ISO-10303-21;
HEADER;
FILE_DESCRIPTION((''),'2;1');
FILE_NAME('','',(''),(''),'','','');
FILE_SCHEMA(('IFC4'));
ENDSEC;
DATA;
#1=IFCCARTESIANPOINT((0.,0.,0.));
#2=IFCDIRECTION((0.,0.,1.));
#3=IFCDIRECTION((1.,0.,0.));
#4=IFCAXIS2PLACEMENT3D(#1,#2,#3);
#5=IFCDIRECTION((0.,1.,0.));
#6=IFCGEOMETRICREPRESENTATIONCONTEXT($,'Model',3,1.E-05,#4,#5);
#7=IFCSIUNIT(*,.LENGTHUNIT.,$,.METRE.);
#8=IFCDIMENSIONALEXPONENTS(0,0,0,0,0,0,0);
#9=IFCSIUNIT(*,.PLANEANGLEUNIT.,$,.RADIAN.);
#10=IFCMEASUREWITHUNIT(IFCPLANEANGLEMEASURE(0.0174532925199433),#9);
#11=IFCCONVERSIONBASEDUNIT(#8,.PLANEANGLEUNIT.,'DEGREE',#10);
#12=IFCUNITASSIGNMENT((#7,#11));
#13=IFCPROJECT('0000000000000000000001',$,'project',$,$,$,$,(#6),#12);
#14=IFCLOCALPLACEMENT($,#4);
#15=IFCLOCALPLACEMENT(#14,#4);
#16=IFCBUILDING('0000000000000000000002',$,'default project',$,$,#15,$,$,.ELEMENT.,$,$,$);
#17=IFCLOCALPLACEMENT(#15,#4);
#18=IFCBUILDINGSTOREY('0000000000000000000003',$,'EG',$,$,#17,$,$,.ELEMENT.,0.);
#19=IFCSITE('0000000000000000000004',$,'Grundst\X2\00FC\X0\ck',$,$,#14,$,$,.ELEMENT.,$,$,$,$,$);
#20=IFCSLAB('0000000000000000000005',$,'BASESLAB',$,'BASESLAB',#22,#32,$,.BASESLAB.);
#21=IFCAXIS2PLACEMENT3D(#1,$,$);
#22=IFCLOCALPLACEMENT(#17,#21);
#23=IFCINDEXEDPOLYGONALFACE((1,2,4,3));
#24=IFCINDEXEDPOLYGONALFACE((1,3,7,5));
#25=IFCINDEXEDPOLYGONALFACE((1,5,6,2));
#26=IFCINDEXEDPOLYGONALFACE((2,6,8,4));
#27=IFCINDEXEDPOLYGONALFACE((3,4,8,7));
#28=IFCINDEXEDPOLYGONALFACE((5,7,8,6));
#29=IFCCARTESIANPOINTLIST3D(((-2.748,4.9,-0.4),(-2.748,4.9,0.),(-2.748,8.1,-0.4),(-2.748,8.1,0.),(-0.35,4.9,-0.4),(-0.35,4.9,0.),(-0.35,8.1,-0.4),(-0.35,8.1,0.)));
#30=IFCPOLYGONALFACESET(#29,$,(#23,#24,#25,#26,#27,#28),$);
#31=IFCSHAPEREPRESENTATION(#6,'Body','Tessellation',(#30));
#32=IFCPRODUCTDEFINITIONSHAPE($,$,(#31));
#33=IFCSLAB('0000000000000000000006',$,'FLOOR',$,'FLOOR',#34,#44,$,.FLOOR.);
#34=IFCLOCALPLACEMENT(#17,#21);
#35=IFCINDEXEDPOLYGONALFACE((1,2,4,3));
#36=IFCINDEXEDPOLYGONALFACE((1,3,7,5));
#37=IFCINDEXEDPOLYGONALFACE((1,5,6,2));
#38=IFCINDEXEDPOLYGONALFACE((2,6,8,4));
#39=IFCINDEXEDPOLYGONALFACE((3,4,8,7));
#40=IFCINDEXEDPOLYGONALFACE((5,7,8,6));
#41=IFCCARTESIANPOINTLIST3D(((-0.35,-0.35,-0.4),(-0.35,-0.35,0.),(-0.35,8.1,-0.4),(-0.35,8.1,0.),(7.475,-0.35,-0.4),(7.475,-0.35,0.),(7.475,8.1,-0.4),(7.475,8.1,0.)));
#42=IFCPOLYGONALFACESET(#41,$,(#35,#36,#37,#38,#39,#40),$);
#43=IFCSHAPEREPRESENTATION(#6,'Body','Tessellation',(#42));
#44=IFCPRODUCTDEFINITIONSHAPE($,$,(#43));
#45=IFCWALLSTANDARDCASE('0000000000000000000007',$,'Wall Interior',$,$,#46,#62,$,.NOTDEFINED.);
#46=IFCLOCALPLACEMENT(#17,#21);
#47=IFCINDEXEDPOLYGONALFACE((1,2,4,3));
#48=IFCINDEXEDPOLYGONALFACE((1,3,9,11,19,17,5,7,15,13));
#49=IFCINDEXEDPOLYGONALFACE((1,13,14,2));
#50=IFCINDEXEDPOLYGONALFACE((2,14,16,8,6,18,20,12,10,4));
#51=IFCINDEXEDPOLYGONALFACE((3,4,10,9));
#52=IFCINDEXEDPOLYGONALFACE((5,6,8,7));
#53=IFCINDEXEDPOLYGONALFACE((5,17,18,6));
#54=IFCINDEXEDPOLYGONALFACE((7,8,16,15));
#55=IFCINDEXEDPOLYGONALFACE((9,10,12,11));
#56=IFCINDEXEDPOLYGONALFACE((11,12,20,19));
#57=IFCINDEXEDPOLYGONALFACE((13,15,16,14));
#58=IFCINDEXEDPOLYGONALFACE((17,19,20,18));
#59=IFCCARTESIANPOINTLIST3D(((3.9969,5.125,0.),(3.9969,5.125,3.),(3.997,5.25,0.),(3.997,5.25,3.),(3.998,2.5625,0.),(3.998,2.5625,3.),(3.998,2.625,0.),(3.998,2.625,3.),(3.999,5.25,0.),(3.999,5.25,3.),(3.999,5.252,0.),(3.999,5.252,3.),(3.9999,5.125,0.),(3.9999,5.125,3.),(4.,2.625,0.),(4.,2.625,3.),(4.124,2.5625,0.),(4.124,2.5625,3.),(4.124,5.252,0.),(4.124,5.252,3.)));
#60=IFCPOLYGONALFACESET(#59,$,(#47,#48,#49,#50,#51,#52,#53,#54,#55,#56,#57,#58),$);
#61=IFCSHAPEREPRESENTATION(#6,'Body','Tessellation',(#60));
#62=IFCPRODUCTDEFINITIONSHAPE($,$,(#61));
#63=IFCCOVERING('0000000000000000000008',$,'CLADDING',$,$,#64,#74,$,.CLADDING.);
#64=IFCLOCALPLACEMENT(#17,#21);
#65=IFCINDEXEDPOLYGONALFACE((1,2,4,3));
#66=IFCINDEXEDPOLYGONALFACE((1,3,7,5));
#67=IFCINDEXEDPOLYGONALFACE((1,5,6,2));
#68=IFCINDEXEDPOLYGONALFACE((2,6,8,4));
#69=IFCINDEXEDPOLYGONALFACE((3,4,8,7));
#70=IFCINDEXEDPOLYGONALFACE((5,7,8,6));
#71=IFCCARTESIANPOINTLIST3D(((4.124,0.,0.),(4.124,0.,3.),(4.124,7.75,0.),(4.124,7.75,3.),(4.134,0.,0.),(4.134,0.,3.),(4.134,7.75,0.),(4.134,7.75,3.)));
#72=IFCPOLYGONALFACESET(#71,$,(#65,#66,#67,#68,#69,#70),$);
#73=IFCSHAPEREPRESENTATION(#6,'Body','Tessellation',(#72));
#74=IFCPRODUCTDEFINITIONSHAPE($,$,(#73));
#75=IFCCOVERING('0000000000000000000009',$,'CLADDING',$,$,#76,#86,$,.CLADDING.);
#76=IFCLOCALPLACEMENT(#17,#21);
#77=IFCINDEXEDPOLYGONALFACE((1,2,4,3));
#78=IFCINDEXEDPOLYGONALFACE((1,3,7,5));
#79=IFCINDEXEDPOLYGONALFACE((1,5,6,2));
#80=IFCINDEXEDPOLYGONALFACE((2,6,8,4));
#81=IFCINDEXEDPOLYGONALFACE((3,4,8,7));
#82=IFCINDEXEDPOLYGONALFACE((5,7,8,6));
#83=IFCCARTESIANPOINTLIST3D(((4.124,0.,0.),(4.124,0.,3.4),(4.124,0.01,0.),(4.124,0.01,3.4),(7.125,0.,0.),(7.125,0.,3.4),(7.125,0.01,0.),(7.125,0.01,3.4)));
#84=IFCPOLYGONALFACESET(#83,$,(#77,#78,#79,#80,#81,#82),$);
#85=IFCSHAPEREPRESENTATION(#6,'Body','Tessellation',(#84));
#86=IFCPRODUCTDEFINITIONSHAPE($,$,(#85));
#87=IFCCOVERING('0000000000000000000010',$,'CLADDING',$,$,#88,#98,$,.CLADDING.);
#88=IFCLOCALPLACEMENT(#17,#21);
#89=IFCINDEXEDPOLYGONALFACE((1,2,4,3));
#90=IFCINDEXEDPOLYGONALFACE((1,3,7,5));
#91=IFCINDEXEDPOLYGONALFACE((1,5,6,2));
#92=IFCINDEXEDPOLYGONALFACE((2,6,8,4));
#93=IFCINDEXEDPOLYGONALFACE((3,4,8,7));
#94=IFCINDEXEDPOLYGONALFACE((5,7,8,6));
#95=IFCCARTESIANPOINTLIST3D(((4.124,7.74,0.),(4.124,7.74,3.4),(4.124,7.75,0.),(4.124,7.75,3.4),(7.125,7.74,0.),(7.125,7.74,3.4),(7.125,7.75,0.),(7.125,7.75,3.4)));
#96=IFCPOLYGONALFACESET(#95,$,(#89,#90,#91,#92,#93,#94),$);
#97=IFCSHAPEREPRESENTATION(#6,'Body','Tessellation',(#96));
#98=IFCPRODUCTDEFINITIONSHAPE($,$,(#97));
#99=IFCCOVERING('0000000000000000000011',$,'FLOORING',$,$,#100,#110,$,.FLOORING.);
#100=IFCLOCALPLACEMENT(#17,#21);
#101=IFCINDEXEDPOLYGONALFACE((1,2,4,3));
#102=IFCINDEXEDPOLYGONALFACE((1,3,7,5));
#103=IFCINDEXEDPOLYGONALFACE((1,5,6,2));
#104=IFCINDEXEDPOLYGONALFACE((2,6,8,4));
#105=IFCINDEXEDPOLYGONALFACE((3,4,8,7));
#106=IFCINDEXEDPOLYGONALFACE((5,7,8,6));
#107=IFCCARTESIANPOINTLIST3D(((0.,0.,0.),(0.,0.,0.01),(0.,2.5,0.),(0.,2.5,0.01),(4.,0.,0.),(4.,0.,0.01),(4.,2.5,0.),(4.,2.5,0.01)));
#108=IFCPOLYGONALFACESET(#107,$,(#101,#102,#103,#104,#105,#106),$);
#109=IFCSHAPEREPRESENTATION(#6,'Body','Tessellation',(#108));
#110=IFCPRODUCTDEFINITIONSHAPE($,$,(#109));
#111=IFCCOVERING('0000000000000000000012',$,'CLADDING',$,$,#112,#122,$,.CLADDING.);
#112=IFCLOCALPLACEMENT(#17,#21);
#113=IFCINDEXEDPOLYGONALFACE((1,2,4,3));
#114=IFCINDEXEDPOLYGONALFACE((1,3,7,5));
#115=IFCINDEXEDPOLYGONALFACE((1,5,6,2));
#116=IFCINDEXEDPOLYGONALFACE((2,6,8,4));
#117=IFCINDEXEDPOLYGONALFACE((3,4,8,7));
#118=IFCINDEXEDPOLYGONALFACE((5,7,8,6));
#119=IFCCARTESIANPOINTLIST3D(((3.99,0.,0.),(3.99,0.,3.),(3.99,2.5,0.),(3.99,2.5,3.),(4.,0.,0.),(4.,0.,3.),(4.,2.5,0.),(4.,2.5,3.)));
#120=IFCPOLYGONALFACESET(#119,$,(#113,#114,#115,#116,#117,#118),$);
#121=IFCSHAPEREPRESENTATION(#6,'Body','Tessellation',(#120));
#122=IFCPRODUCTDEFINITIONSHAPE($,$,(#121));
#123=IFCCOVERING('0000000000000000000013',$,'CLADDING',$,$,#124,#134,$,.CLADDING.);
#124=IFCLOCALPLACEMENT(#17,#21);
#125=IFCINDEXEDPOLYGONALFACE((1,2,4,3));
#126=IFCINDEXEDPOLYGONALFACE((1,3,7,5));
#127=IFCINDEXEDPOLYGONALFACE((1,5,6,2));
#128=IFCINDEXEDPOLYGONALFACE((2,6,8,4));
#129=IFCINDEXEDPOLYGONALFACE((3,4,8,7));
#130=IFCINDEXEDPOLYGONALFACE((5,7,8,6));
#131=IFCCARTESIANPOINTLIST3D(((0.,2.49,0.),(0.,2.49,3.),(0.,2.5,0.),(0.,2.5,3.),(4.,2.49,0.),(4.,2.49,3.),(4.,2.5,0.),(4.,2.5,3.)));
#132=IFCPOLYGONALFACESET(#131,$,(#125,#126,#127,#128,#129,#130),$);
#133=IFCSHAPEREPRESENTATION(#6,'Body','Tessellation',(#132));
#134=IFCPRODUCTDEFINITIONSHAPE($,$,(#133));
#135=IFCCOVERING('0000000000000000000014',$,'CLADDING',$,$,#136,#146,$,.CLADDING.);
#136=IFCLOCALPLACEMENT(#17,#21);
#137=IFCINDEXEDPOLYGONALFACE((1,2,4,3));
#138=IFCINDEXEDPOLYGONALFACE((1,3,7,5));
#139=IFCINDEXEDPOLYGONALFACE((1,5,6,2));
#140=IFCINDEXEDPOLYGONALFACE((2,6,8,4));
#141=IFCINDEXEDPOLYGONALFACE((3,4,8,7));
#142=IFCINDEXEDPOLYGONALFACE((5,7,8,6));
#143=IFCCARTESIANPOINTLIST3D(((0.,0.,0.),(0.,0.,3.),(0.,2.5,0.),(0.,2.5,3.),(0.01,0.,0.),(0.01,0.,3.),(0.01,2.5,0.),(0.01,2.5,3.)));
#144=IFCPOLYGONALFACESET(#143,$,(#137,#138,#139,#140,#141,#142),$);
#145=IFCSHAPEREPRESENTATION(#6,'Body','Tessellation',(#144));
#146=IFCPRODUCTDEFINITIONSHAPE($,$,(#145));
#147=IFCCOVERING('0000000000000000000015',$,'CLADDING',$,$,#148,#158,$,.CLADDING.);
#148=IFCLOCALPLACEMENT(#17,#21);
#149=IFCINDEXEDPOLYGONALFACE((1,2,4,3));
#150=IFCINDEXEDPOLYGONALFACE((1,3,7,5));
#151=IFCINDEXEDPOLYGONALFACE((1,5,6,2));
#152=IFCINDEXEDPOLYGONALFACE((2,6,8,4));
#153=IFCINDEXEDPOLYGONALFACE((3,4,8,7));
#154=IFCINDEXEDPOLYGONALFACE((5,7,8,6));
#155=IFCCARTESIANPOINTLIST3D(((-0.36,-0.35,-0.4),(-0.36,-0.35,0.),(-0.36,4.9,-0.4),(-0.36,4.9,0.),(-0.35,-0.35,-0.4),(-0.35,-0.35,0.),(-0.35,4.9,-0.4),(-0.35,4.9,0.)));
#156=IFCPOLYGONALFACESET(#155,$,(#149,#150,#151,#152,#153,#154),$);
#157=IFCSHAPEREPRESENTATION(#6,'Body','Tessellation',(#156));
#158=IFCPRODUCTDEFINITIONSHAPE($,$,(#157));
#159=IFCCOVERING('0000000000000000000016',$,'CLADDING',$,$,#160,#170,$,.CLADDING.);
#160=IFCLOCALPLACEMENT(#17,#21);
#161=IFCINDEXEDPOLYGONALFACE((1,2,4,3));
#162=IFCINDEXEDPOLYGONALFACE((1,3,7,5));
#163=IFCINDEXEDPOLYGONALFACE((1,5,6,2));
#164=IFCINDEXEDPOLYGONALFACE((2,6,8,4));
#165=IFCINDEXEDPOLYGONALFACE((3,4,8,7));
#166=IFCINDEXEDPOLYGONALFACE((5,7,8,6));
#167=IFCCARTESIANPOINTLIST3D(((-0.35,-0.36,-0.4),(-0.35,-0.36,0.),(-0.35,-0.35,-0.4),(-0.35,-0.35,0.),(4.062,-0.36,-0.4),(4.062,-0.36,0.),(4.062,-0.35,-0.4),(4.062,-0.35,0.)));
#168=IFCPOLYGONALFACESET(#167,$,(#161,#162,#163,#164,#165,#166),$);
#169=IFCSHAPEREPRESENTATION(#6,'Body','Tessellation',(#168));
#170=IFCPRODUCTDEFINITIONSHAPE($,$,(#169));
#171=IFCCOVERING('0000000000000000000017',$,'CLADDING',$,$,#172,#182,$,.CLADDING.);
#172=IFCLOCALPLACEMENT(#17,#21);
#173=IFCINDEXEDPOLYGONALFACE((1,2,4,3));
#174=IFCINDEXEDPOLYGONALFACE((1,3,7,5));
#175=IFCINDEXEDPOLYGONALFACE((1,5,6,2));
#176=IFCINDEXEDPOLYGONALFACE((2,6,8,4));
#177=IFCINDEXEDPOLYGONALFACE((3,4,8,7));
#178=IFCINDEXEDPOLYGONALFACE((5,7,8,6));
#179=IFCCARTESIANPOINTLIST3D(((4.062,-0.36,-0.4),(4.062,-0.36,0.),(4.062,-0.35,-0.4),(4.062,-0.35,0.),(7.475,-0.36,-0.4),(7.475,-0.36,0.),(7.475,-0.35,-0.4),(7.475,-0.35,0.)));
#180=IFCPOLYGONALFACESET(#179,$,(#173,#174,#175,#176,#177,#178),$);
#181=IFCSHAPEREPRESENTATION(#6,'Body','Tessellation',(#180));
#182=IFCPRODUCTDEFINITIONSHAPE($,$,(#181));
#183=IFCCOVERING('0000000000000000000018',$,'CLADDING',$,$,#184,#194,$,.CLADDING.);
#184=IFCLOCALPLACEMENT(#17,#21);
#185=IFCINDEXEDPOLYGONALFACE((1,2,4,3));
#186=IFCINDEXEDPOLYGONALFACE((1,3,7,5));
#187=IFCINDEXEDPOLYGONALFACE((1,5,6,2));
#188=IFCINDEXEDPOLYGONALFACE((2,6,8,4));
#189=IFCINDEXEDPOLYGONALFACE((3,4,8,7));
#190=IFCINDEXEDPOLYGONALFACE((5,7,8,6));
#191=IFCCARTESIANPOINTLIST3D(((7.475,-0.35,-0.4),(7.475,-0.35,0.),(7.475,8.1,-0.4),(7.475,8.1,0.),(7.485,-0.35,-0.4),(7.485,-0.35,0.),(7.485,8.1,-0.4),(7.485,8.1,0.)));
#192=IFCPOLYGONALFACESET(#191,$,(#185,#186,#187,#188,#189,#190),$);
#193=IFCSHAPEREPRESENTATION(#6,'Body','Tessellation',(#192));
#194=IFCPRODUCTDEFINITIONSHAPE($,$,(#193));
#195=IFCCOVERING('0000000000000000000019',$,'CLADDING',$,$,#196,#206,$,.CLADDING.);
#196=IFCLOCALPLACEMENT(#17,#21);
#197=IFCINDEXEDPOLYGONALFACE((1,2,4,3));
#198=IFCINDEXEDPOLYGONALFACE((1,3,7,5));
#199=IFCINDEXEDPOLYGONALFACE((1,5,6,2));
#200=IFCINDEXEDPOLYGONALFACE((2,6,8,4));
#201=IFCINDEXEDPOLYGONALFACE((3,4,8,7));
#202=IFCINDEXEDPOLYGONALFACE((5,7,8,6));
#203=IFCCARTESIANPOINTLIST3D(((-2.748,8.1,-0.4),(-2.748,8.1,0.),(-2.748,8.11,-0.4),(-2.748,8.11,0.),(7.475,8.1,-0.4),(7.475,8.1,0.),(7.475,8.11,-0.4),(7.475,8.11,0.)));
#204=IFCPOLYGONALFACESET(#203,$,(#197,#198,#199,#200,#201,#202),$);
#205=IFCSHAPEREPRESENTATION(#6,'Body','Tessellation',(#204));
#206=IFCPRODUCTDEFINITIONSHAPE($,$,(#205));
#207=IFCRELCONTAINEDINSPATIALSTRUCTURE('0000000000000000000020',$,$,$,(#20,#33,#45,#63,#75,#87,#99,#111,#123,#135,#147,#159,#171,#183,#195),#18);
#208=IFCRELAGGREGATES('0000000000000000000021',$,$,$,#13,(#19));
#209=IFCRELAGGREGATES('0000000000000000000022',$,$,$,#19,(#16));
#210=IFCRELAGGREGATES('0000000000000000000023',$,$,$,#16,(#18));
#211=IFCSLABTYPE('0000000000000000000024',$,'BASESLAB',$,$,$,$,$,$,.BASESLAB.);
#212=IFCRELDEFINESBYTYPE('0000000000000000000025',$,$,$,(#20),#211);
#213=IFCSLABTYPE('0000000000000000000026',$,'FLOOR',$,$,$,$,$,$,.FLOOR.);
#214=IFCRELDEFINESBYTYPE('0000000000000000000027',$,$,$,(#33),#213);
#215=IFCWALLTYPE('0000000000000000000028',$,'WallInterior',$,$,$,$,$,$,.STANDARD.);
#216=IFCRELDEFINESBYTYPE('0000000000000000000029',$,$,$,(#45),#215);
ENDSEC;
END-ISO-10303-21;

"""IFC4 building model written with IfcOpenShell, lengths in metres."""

from ifc_helpers import new_model, entity, si_unit, converted_unit, direction, frame, origin_with_axes, place, context, project, spatial, polyline, outline, extrude, type_object, element, save


model = new_model("IFC4")

# Units and contexts
model_context = context("Model", 3, precision=1e-05, world=origin_with_axes(), true_north=direction((0.0, 1.0, 0.0)))
ifc_project = project(units=[si_unit("LENGTHUNIT", "METRE"), converted_unit("PLANEANGLEUNIT", "DEGREE", entity("IfcPlaneAngleMeasure", 0.0174532925199433), si_unit("PLANEANGLEUNIT", "RADIAN"), dimensions=[0, 0, 0, 0, 0, 0, 0])], contexts=[model_context])

# Site, building, storey
site_placement = place(None, origin_with_axes())
site = spatial("IfcSite", under=ifc_project, at=site_placement, Name="Grundstück", CompositionType="ELEMENT")
building_placement = place(site_placement, origin_with_axes())
building = spatial("IfcBuilding", under=site, at=building_placement, Name="default project", CompositionType="ELEMENT")
placement_1 = place(building_placement, origin_with_axes())
storey = spatial("IfcBuildingStorey", under=building, at=placement_1, Name="EG", CompositionType="ELEMENT", Elevation=0.0)

# Slabs
slab_type_1 = type_object("IfcSlabType", Name="BASESLAB", PredefinedType="BASESLAB")
slab_1_placement = place(placement_1, frame((0.0, 0.0, -0.4), z_axis=(0.0, 0.0, 1.0), x_axis=(1.0, 0.0, 0.0)))
element("IfcSlab", 1, at=slab_1_placement, inside=storey, type_object=slab_type_1, Name="BASESLAB", ObjectType="BASESLAB", PredefinedType="BASESLAB", context=model_context, shape_type="SweptSolid", body=[
    extrude(outline(polyline([(-0.35, 8.1), (-2.748, 8.1), (-2.748, 4.9), (-0.35, 4.9), (-0.35, 8.1)])), origin_with_axes(), (0.0, 0.0, 1.0), 0.4),
])
slab_type_2 = type_object("IfcSlabType", Name="FLOOR", PredefinedType="FLOOR")
slab_2_placement = place(placement_1, frame((0.0, 0.0, -0.4), z_axis=(0.0, 0.0, 1.0), x_axis=(1.0, 0.0, 0.0)))
element("IfcSlab", 2, at=slab_2_placement, inside=storey, type_object=slab_type_2, Name="FLOOR", ObjectType="FLOOR", PredefinedType="FLOOR", context=model_context, shape_type="SweptSolid", body=[
    extrude(outline(polyline([(7.475, 8.1), (-0.35, 8.1), (-0.35, -0.35), (7.475, -0.35), (7.475, 8.1)])), origin_with_axes(), (0.0, 0.0, 1.0), 0.4),
])

# Wall
wall_type_1 = type_object("IfcWallType", Name="WallInterior", PredefinedType="STANDARD")
wall_1_placement = place(placement_1, frame((4.062, 2.5625, 0.0), z_axis=(0.0, 0.0, 1.0), x_axis=(-0.0001, 1.0, 0.0)))
element("IfcWallStandardCase", 3, at=wall_1_placement, inside=storey, type_object=wall_type_1, Name="Wall Interior", PredefinedType="NOTDEFINED", context=model_context, shape_type="SweptSolid", body=[
    extrude(outline(polyline([(2.6875, 0.0647), (2.5625, 0.0648), (2.5625, 0.0618), (0.0625, 0.062), (0.0625, 0.064), (0.0, 0.064), (0.0, -0.062), (2.6895, -0.0623), (2.6895, 0.0627), (2.6875, 0.0627), (2.6875, 0.0647)])), origin_with_axes(), (0.0, 0.0, 1.0), 3.0),
])

# Coverings
element("IfcCovering", 4, at=placement_1, inside=storey, Name="CLADDING", PredefinedType="CLADDING", context=model_context, shape_type="SweptSolid", body=[
    extrude(outline(polyline([(4.134, 0.0), (4.134, 7.75), (4.124, 7.75), (4.124, 0.0), (4.134, 0.0)])), origin_with_axes(), (0.0, 0.0, 1.0), 3.0),
])
element("IfcCovering", 5, at=placement_1, inside=storey, Name="CLADDING", PredefinedType="CLADDING", context=model_context, shape_type="SweptSolid", body=[
    extrude(outline(polyline([(7.125, 0.01), (4.124, 0.01), (4.124, 0.0), (7.125, 0.0), (7.125, 0.01)])), origin_with_axes(), (0.0, 0.0, 1.0), 3.4),
])
element("IfcCovering", 6, at=placement_1, inside=storey, Name="CLADDING", PredefinedType="CLADDING", context=model_context, shape_type="SweptSolid", body=[
    extrude(outline(polyline([(4.124, 7.74), (7.125, 7.74), (7.125, 7.75), (4.124, 7.75), (4.124, 7.74)])), origin_with_axes(), (0.0, 0.0, 1.0), 3.4),
])
element("IfcCovering", 7, at=placement_1, inside=storey, Name="FLOORING", PredefinedType="FLOORING", context=model_context, shape_type="SweptSolid", body=[
    extrude(outline(polyline([(4.0, 2.5), (0.0, 2.5), (0.0, 0.0), (4.0, 0.0), (4.0, 2.5)])), origin_with_axes(), (0.0, 0.0, 1.0), 0.01),
])
element("IfcCovering", 8, at=placement_1, inside=storey, Name="CLADDING", PredefinedType="CLADDING", context=model_context, shape_type="SweptSolid", body=[
    extrude(outline(polyline([(3.99, 2.5), (3.99, 0.0), (4.0, 0.0), (4.0, 2.5), (3.99, 2.5)])), origin_with_axes(), (0.0, 0.0, 1.0), 3.0),
])
element("IfcCovering", 9, at=placement_1, inside=storey, Name="CLADDING", PredefinedType="CLADDING", context=model_context, shape_type="SweptSolid", body=[
    extrude(outline(polyline([(0.0, 2.49), (4.0, 2.49), (4.0, 2.5), (0.0, 2.5), (0.0, 2.49)])), origin_with_axes(), (0.0, 0.0, 1.0), 3.0),
])
element("IfcCovering", 10, at=placement_1, inside=storey, Name="CLADDING", PredefinedType="CLADDING", context=model_context, shape_type="SweptSolid", body=[
    extrude(outline(polyline([(0.01, 0.0), (0.01, 2.5), (0.0, 2.5), (0.0, 0.0), (0.01, 0.0)])), origin_with_axes(), (0.0, 0.0, 1.0), 3.0),
])
covering_1_placement = place(slab_2_placement, origin_with_axes())
element("IfcCovering", 11, at=covering_1_placement, inside=storey, Name="CLADDING", PredefinedType="CLADDING", context=model_context, shape_type="SweptSolid", body=[
    extrude(outline(polyline([(-0.36, 4.9), (-0.36, -0.35), (-0.35, -0.35), (-0.35, 4.9), (-0.36, 4.9)])), origin_with_axes(), (0.0, 0.0, 1.0), 0.4),
])
covering_2_placement = place(slab_2_placement, origin_with_axes())
element("IfcCovering", 12, at=covering_2_placement, inside=storey, Name="CLADDING", PredefinedType="CLADDING", context=model_context, shape_type="SweptSolid", body=[
    extrude(outline(polyline([(-0.35, -0.36), (4.062, -0.36), (4.062, -0.35), (-0.35, -0.35), (-0.35, -0.36)])), origin_with_axes(), (0.0, 0.0, 1.0), 0.4),
])
covering_3_placement = place(slab_2_placement, origin_with_axes())
element("IfcCovering", 13, at=covering_3_placement, inside=storey, Name="CLADDING", PredefinedType="CLADDING", context=model_context, shape_type="SweptSolid", body=[
    extrude(outline(polyline([(4.062, -0.36), (7.475, -0.36), (7.475, -0.35), (4.062, -0.35), (4.062, -0.36)])), origin_with_axes(), (0.0, 0.0, 1.0), 0.4),
])
covering_4_placement = place(slab_2_placement, origin_with_axes())
element("IfcCovering", 14, at=covering_4_placement, inside=storey, Name="CLADDING", PredefinedType="CLADDING", context=model_context, shape_type="SweptSolid", body=[
    extrude(outline(polyline([(7.485, -0.35), (7.485, 8.1), (7.475, 8.1), (7.475, -0.35), (7.485, -0.35)])), origin_with_axes(), (0.0, 0.0, 1.0), 0.4),
])
covering_5_placement = place(slab_2_placement, origin_with_axes())
element("IfcCovering", 15, at=covering_5_placement, inside=storey, Name="CLADDING", PredefinedType="CLADDING", context=model_context, shape_type="SweptSolid", body=[
    extrude(outline(polyline([(7.475, 8.11), (-2.748, 8.11), (-2.748, 8.1), (7.475, 8.1), (7.475, 8.11)])), origin_with_axes(), (0.0, 0.0, 1.0), 0.4),
])

save(model, "model.ifc")
